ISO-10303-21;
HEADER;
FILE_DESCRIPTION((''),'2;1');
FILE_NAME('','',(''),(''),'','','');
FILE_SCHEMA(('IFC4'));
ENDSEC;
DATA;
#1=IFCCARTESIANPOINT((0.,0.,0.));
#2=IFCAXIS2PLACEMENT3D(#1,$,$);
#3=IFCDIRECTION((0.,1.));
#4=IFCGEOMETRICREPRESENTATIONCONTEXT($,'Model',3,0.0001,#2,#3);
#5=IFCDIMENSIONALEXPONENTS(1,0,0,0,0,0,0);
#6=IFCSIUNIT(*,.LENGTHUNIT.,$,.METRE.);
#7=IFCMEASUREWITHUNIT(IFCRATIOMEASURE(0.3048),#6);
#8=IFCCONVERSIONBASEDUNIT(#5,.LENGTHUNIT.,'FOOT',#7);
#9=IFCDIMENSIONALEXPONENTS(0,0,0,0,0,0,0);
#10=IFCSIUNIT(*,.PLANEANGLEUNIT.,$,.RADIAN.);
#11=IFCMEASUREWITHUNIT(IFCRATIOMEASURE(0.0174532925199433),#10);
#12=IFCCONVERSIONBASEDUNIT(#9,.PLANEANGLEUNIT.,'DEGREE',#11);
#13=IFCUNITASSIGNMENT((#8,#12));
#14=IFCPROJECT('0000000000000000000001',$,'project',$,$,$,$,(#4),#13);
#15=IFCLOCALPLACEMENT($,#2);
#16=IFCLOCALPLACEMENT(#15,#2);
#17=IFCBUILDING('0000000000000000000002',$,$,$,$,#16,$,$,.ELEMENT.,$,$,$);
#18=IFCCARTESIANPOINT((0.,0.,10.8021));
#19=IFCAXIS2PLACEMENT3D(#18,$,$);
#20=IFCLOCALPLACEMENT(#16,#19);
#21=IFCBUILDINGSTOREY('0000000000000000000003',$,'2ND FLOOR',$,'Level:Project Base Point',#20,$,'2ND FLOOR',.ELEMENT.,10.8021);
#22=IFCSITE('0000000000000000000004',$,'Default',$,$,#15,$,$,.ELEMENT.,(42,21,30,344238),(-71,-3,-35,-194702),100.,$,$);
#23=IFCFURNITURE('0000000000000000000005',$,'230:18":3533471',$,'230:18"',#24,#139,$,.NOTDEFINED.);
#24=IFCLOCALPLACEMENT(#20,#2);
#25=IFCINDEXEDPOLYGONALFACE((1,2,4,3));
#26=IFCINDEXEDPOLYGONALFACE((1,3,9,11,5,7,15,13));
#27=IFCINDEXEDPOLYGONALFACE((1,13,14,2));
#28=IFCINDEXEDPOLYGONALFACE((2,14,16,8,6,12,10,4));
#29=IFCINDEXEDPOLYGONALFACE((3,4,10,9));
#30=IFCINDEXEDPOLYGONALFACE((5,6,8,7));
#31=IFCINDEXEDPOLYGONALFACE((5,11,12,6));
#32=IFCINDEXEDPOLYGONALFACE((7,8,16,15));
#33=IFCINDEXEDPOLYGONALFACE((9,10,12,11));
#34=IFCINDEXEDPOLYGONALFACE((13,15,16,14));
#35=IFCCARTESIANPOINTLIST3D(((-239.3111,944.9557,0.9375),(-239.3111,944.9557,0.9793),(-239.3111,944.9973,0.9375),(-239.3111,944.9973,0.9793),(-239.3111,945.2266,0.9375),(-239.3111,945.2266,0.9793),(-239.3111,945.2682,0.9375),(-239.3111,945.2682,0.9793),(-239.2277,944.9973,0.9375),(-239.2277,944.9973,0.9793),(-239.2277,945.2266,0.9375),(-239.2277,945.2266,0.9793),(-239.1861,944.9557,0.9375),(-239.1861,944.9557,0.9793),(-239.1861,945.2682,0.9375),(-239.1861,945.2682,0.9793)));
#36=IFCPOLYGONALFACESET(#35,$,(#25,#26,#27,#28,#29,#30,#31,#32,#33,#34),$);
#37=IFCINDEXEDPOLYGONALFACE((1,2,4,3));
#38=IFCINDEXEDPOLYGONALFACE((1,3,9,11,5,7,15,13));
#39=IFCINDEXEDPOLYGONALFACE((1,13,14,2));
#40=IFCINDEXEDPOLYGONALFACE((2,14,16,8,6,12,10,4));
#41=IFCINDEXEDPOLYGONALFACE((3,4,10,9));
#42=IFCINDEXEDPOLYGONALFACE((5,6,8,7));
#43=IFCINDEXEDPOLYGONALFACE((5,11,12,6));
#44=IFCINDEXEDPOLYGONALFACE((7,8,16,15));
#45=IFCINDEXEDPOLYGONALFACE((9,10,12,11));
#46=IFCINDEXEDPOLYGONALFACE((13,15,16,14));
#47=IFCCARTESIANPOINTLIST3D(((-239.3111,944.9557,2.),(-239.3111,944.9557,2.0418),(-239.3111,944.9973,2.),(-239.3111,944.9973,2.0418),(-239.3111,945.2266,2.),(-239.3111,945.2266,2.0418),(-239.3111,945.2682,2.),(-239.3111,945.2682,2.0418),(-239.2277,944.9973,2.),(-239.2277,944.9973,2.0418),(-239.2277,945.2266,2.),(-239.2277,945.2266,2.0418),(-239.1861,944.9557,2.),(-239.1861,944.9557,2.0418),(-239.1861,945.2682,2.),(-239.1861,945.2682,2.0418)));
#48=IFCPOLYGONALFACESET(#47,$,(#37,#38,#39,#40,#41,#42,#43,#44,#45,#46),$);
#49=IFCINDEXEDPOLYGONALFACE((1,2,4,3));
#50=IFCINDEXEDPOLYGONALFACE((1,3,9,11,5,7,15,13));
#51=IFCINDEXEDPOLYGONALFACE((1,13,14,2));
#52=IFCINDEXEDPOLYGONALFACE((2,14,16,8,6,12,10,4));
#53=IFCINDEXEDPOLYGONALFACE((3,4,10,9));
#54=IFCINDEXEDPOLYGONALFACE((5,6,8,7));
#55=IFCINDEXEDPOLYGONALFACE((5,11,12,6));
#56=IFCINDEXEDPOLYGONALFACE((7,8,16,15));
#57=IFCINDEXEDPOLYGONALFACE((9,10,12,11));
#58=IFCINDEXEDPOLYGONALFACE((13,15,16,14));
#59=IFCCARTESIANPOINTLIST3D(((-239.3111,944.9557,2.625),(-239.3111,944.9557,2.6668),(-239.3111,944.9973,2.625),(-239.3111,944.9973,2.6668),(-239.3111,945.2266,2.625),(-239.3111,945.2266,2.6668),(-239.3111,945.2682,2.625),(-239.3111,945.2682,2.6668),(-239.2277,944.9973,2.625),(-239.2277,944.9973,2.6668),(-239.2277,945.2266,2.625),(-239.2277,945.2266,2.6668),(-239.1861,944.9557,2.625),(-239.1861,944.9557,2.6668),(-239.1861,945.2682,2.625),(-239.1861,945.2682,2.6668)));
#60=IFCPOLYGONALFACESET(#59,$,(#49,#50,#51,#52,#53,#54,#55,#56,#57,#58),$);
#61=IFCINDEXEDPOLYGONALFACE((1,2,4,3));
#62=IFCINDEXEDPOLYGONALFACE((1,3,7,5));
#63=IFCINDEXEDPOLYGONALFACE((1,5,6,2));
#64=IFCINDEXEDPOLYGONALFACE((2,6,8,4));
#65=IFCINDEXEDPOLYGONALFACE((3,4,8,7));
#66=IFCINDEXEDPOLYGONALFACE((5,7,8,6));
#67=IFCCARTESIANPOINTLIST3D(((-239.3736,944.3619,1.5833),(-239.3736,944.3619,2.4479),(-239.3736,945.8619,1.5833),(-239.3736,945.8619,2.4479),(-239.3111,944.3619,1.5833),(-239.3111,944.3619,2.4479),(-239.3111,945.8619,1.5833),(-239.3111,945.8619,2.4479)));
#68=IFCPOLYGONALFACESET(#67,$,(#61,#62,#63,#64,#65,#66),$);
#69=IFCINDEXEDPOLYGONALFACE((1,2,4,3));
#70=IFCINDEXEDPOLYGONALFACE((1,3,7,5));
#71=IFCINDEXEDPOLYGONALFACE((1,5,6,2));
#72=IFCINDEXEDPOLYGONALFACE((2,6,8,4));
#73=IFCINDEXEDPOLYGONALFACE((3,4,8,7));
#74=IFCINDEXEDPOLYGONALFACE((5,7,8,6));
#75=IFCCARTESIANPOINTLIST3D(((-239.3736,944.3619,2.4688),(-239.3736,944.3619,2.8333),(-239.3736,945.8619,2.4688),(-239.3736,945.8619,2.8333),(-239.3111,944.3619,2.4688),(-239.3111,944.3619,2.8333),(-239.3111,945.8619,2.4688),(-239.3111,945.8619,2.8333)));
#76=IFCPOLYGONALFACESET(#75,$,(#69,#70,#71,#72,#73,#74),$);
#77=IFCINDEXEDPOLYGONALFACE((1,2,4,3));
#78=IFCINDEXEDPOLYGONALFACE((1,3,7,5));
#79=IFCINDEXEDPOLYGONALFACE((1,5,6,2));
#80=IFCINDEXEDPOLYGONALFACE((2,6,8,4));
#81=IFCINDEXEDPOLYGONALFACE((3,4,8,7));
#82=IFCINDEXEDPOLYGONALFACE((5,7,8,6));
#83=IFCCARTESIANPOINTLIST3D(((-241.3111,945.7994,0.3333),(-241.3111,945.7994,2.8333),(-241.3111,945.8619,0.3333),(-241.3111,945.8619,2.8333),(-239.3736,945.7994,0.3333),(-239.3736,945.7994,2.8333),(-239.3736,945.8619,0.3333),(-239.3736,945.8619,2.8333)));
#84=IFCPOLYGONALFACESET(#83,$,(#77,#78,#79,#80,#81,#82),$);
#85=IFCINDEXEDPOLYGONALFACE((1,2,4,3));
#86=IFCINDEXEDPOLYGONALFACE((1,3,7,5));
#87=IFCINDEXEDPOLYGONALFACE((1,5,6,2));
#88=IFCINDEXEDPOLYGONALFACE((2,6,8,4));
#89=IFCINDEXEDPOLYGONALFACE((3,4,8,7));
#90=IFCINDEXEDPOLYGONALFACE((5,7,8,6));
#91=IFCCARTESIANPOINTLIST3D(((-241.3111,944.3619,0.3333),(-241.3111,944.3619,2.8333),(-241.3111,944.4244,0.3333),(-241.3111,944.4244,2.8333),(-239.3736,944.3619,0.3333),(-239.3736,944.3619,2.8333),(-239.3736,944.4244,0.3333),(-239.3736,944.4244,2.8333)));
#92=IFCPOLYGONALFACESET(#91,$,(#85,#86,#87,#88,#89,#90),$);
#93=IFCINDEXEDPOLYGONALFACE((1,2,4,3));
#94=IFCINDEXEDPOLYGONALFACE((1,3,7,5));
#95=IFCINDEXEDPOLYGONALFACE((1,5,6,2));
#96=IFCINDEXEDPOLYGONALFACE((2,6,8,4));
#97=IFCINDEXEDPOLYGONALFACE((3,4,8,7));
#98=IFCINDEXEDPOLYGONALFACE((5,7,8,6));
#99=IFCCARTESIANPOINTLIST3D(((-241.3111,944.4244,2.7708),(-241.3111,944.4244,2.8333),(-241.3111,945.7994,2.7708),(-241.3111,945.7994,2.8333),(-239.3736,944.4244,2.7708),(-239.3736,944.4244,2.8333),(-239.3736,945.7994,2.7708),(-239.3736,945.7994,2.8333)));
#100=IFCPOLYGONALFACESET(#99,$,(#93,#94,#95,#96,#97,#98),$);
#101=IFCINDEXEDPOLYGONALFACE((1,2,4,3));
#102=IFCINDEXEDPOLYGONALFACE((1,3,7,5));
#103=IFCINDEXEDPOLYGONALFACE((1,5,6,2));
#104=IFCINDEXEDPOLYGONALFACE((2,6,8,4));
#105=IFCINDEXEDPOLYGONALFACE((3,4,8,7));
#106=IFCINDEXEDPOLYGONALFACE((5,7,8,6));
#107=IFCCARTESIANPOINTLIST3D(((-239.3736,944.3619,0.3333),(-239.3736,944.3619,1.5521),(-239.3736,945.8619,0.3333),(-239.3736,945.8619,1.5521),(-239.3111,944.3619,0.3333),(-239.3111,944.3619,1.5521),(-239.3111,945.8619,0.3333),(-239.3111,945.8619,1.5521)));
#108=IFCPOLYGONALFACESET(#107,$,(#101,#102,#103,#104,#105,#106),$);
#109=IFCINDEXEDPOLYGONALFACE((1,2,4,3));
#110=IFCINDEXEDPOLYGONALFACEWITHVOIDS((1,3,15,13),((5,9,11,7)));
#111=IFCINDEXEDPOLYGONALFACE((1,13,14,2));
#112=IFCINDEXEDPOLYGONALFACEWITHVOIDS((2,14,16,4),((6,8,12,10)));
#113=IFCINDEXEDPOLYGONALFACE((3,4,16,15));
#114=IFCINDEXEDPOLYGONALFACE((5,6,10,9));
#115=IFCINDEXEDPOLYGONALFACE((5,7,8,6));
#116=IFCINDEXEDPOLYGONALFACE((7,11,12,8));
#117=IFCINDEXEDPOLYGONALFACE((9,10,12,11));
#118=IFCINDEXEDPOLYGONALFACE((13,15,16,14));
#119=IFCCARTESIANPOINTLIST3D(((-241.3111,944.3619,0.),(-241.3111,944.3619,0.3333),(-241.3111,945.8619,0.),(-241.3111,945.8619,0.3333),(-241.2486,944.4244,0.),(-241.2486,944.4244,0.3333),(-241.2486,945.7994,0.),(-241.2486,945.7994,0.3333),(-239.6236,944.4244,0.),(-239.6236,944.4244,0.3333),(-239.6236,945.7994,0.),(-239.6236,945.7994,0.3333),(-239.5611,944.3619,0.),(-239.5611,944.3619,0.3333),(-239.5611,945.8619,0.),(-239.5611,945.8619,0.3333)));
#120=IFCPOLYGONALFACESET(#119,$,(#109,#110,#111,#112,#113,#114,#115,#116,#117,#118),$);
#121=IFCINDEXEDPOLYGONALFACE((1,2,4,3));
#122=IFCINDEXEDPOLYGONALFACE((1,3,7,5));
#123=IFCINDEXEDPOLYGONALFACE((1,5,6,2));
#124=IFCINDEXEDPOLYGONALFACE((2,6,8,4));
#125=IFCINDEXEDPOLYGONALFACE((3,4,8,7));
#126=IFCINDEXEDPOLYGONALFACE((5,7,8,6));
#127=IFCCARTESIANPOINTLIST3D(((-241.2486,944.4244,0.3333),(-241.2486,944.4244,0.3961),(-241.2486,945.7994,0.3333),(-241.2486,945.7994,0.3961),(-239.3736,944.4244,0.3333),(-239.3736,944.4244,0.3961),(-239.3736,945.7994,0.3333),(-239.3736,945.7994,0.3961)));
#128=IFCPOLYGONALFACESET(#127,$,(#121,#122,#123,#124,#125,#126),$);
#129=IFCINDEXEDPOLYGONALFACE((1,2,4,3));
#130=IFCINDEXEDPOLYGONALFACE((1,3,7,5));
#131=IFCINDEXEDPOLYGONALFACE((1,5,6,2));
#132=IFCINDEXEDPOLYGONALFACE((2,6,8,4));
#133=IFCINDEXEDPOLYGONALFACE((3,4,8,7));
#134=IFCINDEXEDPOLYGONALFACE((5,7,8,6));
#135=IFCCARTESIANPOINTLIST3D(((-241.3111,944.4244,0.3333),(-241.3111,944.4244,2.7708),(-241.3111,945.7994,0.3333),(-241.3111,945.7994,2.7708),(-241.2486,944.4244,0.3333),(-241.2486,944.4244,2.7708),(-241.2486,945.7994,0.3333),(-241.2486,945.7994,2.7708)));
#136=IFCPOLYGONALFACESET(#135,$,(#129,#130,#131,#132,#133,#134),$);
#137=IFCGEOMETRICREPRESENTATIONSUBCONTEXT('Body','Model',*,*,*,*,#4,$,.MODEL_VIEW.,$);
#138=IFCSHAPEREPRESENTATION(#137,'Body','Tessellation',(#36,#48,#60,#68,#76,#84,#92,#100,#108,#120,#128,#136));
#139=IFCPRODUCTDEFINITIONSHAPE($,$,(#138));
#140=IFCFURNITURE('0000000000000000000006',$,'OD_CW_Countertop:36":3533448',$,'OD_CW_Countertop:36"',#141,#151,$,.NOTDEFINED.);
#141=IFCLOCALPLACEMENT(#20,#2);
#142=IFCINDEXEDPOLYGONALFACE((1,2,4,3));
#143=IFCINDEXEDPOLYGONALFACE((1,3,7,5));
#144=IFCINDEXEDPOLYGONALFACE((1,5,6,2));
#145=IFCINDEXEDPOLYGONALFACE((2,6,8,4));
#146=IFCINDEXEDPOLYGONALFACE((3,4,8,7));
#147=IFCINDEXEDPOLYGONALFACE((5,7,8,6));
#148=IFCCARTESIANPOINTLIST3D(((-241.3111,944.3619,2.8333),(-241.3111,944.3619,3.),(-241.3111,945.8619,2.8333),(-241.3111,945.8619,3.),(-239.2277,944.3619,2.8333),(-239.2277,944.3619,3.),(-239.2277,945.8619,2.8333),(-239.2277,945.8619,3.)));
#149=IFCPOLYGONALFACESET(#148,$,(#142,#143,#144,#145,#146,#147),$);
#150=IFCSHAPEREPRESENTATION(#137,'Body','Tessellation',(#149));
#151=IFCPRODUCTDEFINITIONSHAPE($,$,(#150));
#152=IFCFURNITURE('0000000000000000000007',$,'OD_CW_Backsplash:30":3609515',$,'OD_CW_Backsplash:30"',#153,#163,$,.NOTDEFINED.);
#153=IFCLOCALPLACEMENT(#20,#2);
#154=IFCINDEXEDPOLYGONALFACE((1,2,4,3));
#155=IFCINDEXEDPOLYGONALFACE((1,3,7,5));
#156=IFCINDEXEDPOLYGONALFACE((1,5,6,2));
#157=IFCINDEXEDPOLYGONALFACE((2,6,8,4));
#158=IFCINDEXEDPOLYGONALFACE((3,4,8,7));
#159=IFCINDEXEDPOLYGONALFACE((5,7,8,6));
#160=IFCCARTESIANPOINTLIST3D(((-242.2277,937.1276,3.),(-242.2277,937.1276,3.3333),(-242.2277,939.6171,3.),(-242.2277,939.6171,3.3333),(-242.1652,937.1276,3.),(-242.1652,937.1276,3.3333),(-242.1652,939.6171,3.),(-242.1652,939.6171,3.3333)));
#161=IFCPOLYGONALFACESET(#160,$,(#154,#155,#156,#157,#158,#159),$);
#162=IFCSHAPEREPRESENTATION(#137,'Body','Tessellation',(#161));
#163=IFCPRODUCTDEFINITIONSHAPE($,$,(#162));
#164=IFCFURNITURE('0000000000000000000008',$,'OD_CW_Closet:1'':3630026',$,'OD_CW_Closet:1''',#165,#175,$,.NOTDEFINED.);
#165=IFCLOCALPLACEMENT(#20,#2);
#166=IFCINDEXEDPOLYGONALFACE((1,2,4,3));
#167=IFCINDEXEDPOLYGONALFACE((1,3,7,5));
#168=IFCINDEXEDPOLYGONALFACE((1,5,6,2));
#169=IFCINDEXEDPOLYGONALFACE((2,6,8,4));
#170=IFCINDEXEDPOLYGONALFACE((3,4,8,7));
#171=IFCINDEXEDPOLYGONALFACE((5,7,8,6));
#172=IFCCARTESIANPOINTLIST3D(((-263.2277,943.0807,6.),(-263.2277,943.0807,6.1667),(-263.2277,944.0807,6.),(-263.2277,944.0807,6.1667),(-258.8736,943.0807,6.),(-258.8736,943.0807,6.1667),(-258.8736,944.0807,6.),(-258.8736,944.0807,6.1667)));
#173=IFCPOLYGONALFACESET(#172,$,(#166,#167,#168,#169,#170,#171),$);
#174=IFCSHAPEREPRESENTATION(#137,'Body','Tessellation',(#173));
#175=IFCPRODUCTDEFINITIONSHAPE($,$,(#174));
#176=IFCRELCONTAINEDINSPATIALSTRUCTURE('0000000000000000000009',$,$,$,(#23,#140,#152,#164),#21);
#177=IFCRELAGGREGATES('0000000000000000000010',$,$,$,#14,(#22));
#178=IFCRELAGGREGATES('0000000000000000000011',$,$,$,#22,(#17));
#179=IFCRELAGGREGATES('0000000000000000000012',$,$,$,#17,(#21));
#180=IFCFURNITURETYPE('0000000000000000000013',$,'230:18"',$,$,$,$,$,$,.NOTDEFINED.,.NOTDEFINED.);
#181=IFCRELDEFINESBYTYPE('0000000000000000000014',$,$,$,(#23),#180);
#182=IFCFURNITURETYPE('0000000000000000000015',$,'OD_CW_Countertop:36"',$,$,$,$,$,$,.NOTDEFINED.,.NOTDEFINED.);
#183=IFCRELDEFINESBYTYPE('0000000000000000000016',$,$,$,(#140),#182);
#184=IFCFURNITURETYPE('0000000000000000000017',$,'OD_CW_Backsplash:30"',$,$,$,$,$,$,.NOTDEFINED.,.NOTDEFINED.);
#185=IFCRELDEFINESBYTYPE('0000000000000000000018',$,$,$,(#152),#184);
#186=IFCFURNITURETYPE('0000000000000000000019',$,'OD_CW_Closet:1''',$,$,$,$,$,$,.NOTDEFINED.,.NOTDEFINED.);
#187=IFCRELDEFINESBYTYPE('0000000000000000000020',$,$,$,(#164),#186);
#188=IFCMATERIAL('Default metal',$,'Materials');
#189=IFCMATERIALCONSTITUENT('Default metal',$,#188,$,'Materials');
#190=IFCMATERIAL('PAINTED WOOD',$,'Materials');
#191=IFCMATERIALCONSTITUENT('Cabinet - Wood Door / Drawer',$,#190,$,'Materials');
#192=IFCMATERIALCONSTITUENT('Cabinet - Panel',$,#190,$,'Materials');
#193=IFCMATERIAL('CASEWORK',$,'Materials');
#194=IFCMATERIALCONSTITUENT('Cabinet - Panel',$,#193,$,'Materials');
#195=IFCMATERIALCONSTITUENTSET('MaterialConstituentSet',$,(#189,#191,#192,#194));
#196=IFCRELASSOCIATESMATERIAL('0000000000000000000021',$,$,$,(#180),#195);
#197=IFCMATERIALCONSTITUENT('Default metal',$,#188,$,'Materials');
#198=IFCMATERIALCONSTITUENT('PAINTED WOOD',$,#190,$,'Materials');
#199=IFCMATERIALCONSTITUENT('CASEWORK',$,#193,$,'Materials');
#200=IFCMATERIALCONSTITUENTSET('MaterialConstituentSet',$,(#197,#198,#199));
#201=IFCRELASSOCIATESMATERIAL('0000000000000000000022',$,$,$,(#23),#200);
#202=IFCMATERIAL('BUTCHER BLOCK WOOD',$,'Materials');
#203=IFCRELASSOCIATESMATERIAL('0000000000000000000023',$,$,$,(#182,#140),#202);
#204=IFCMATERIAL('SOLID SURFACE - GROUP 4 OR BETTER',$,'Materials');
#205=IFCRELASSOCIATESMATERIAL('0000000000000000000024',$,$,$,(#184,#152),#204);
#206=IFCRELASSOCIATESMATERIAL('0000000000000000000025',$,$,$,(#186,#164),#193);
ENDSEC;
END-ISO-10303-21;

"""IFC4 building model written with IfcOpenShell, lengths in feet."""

from ifc_helpers import new_model, entity, si_unit, converted_unit, direction, frame, frame_2d, origin, origin_2d_with_axis, place, context, subcontext, project, spatial, polyline, rectangle, outline, extrude, source, transform, mapped, material, constituent, constituent_set, type_object, type_shapes, element, save


model = new_model("IFC4")

# Units and contexts
model_context = context("Model", 3, precision=0.0001, world=origin(), true_north=direction((0.0, 1.0)))
body_context = subcontext(model_context, "Body", "Model", "MODEL_VIEW")
ifc_project = project(units=[converted_unit("LENGTHUNIT", "FOOT", entity("IfcRatioMeasure", 0.3048), si_unit("LENGTHUNIT", "METRE"), dimensions=[1, 0, 0, 0, 0, 0, 0]), converted_unit("PLANEANGLEUNIT", "DEGREE", entity("IfcRatioMeasure", 0.0174532925199433), si_unit("PLANEANGLEUNIT", "RADIAN"), dimensions=[0, 0, 0, 0, 0, 0, 0])], contexts=[model_context])

# Site, building, storey
site_placement = place(None, origin())
site = spatial("IfcSite", under=ifc_project, at=site_placement, Name="Default", CompositionType="ELEMENT", RefLatitude=(42, 21, 30, 344238), RefLongitude=(-71, -3, -35, -194702), RefElevation=100.0)
building_placement = place(site_placement, origin())
building = spatial("IfcBuilding", under=site, at=building_placement, CompositionType="ELEMENT")
storey_placement = place(building_placement, frame((0.0, 0.0, 10.8021)))
storey = spatial("IfcBuildingStorey", under=building, at=storey_placement, Name="2ND FLOOR", ObjectType="Level:Project Base Point", LongName="2ND FLOOR", CompositionType="ELEMENT", Elevation=10.8021)

# Furniture
ifc_material_1 = material(Name="CASEWORK", Category="Materials")
ifc_material_2 = material(Name="PAINTED WOOD", Category="Materials")
ifc_material_3 = material(Name="SOLID SURFACE - GROUP 4 OR BETTER", Category="Materials")
ifc_material_4 = material(Name="BUTCHER BLOCK WOOD", Category="Materials")
ifc_material_5 = material(Name="Default metal", Category="Materials")
ifc_constituent_1 = constituent(ifc_material_5, Name="Default metal", Category="Materials")
ifc_constituent_2 = constituent(ifc_material_2, Name="PAINTED WOOD", Category="Materials")
ifc_constituent_3 = constituent(ifc_material_1, Name="CASEWORK", Category="Materials")
ifc_constituent_set_1 = constituent_set(constituents=[ifc_constituent_1, ifc_constituent_2, ifc_constituent_3], Name="MaterialConstituentSet")
ifc_constituent_4 = constituent(ifc_material_5, Name="Default metal", Category="Materials")
ifc_constituent_5 = constituent(ifc_material_2, Name="Cabinet - Wood Door / Drawer", Category="Materials")
ifc_constituent_6 = constituent(ifc_material_2, Name="Cabinet - Panel", Category="Materials")
ifc_constituent_7 = constituent(ifc_material_1, Name="Cabinet - Panel", Category="Materials")
ifc_constituent_set_2 = constituent_set(constituents=[ifc_constituent_4, ifc_constituent_5, ifc_constituent_6, ifc_constituent_7], Name="MaterialConstituentSet")
furniture_type_1 = type_object("IfcFurnitureType", Name="230:18\"", AssemblyPlace="NOTDEFINED", PredefinedType="NOTDEFINED", material=ifc_constituent_set_2)
shared_shape_1 = source(origin(), body_context, "Body", "SweptSolid", [
    extrude(outline(polyline([(-0.1562, -0.0521), (-0.1146, -0.0521), (-0.1146, 0.0313), (0.1146, 0.0313), (0.1146, -0.0521), (0.1562, -0.0521), (0.1562, 0.0729), (-0.1562, 0.0729), (-0.1562, -0.0521)])), frame((0.0615, 2.0521, 0.9375)), (0.0, 0.0, 1.0), 0.0418),
    extrude(outline(polyline([(-0.1562, -0.0521), (-0.1146, -0.0521), (-0.1146, 0.0313), (0.1146, 0.0313), (0.1146, -0.0521), (0.1562, -0.0521), (0.1562, 0.0729), (-0.1562, 0.0729), (-0.1562, -0.0521)])), frame((0.0615, 2.0521, 2.0)), (0.0, 0.0, 1.0), 0.0418),
    extrude(outline(polyline([(-0.1562, -0.0521), (-0.1146, -0.0521), (-0.1146, 0.0313), (0.1146, 0.0313), (0.1146, -0.0521), (0.1562, -0.0521), (0.1562, 0.0729), (-0.1562, 0.0729), (-0.1562, -0.0521)])), frame((0.0615, 2.0521, 2.625)), (0.0, 0.0, 1.0), 0.0418),
    extrude(rectangle(XDim=1.5, YDim=0.0625, at=frame_2d((0.0, 0.0), x_axis=(1.0, 0.0))), frame((0.0615, 1.9688, 1.5833), z_axis=(0.0, 0.0, 1.0), x_axis=(-1.0, 0.0, 0.0)), (0.0, 0.0, 1.0), 0.8646),
    extrude(rectangle(XDim=1.5, YDim=0.0625, at=frame_2d((0.0, 0.0), x_axis=(1.0, 0.0))), frame((0.0615, 1.9688, 2.4688), z_axis=(0.0, 0.0, 1.0), x_axis=(-1.0, 0.0, 0.0)), (0.0, 0.0, 1.0), 0.3646),
    extrude(rectangle(XDim=1.9375, YDim=0.0625, at=frame_2d((0.0, 0.0), x_axis=(1.0, 0.0))), frame((-0.6573, 0.9687, 0.3333), z_axis=(0.0, 0.0, 1.0), x_axis=(0.0, -1.0, 0.0)), (0.0, 0.0, 1.0), 2.5),
    extrude(rectangle(XDim=1.9375, YDim=0.0625, at=frame_2d((0.0, 0.0), x_axis=(1.0, 0.0))), frame((0.7802, 0.9687, 0.3333), z_axis=(0.0, 0.0, 1.0), x_axis=(0.0, -1.0, 0.0)), (0.0, 0.0, 1.0), 2.5),
    extrude(rectangle(XDim=1.9375, YDim=1.375, at=origin_2d_with_axis()), frame((0.0615, 0.9687, 2.7708), z_axis=(0.0, 0.0, 1.0), x_axis=(0.0, 1.0, 0.0)), (0.0, 0.0, 1.0), 0.0625),
    extrude(rectangle(XDim=1.5, YDim=0.0625, at=frame_2d((0.0, 0.0), x_axis=(1.0, 0.0))), frame((0.0615, 1.9688, 0.3333), z_axis=(0.0, 0.0, 1.0), x_axis=(-1.0, 0.0, 0.0)), (0.0, 0.0, 1.0), 1.2187),
    extrude(outline(polyline([(-0.875, -0.75), (0.875, -0.75), (0.875, 0.75), (-0.875, 0.75), (-0.875, -0.75)]), holes=[polyline([(-0.8125, -0.6875), (-0.8125, 0.6875), (0.8125, 0.6875), (0.8125, -0.6875), (-0.8125, -0.6875)])]), frame((0.0615, 0.875, 0.0), z_axis=(0.0, 0.0, 1.0), x_axis=(0.0, -1.0, 0.0)), (0.0, 0.0, 1.0), 0.3333),
    extrude(rectangle(XDim=1.875, YDim=1.375, at=origin_2d_with_axis()), frame((0.0615, 1.0, 0.3333), z_axis=(0.0, 0.0, 1.0), x_axis=(0.0, 1.0, 0.0)), (0.0, 0.0, 1.0), 0.0627),
    extrude(rectangle(XDim=1.375, YDim=0.0625, at=origin_2d_with_axis()), frame((0.0615, 0.0312, 0.3333), z_axis=(0.0, 0.0, 1.0), x_axis=(-1.0, 0.0, 0.0)), (0.0, 0.0, 1.0), 2.4375),
])
type_shapes(furniture_type_1, [shared_shape_1])
furniture_1_placement = place(storey_placement, frame((-241.3111, 945.1734, 0.0), z_axis=(0.0, 0.0, 1.0), x_axis=(0.0, -1.0, 0.0)))
element("IfcFurniture", 1, at=furniture_1_placement, inside=storey, type_object=furniture_type_1, material=ifc_constituent_set_1, Name="230:18\":3533471", ObjectType="230:18\"", PredefinedType="NOTDEFINED", context=body_context, shape_type="MappedRepresentation", body=[
    mapped(shared_shape_1, transform((0.0, 0.0, 0.0), scale=1.0)),
])
furniture_type_2 = type_object("IfcFurnitureType", Name="OD_CW_Countertop:36\"", AssemblyPlace="NOTDEFINED", PredefinedType="NOTDEFINED", material=ifc_material_4)
shared_shape_2 = source(origin(), body_context, "Body", "SweptSolid", [
    extrude(rectangle(XDim=2.0833, YDim=1.5, at=origin_2d_with_axis()), frame((0.75, 1.0417, 0.0), z_axis=(0.0, 0.0, 1.0), x_axis=(0.0, -1.0, 0.0)), (0.0, 0.0, 1.0), 0.1667),
])
type_shapes(furniture_type_2, [shared_shape_2])
furniture_2_placement = place(storey_placement, frame((-239.2277, 944.3619, 2.8333), z_axis=(0.0, 0.0, 1.0), x_axis=(0.0, 1.0, 0.0)))
element("IfcFurniture", 2, at=furniture_2_placement, inside=storey, type_object=furniture_type_2, material=ifc_material_4, Name="OD_CW_Countertop:36\":3533448", ObjectType="OD_CW_Countertop:36\"", PredefinedType="NOTDEFINED", context=body_context, shape_type="MappedRepresentation", body=[
    mapped(shared_shape_2, transform((0.0, 0.0, 0.0), scale=1.0)),
])
furniture_type_3 = type_object("IfcFurnitureType", Name="OD_CW_Backsplash:30\"", AssemblyPlace="NOTDEFINED", PredefinedType="NOTDEFINED", material=ifc_material_3)
shared_shape_3 = source(origin(), body_context, "Body", "SweptSolid", [
    extrude(rectangle(XDim=2.4896, YDim=0.0625, at=frame_2d((0.0, 0.0), x_axis=(1.0, 0.0))), frame((1.2448, 0.0313, 0.0)), (0.0, 0.0, 1.0), 0.3333),
])
type_shapes(furniture_type_3, [shared_shape_3])
furniture_3_placement = place(storey_placement, frame((-242.1652, 937.1276, 3.0), z_axis=(0.0, 0.0, 1.0), x_axis=(0.0, 1.0, 0.0)))
element("IfcFurniture", 3, at=furniture_3_placement, inside=storey, type_object=furniture_type_3, material=ifc_material_3, Name="OD_CW_Backsplash:30\":3609515", ObjectType="OD_CW_Backsplash:30\"", PredefinedType="NOTDEFINED", context=body_context, shape_type="MappedRepresentation", body=[
    mapped(shared_shape_3, transform((0.0, 0.0, 0.0), scale=1.0)),
])
furniture_type_4 = type_object("IfcFurnitureType", Name="OD_CW_Closet:1'", AssemblyPlace="NOTDEFINED", PredefinedType="NOTDEFINED", material=ifc_material_1)
shared_shape_4 = source(origin(), body_context, "Body", "SweptSolid", [
    extrude(rectangle(XDim=4.3542, YDim=1.0, at=frame_2d((0.0, 0.0), x_axis=(1.0, 0.0))), frame((2.1771, 0.5, 0.0)), (0.0, 0.0, 1.0), 0.1667),
])
type_shapes(furniture_type_4, [shared_shape_4])
furniture_4_placement = place(storey_placement, frame((-263.2277, 943.0807, 6.0)))
element("IfcFurniture", 4, at=furniture_4_placement, inside=storey, type_object=furniture_type_4, material=ifc_material_1, Name="OD_CW_Closet:1':3630026", ObjectType="OD_CW_Closet:1'", PredefinedType="NOTDEFINED", context=body_context, shape_type="MappedRepresentation", body=[
    mapped(shared_shape_4, transform((0.0, 0.0, 0.0), scale=1.0)),
])

save(model, "model.ifc")
